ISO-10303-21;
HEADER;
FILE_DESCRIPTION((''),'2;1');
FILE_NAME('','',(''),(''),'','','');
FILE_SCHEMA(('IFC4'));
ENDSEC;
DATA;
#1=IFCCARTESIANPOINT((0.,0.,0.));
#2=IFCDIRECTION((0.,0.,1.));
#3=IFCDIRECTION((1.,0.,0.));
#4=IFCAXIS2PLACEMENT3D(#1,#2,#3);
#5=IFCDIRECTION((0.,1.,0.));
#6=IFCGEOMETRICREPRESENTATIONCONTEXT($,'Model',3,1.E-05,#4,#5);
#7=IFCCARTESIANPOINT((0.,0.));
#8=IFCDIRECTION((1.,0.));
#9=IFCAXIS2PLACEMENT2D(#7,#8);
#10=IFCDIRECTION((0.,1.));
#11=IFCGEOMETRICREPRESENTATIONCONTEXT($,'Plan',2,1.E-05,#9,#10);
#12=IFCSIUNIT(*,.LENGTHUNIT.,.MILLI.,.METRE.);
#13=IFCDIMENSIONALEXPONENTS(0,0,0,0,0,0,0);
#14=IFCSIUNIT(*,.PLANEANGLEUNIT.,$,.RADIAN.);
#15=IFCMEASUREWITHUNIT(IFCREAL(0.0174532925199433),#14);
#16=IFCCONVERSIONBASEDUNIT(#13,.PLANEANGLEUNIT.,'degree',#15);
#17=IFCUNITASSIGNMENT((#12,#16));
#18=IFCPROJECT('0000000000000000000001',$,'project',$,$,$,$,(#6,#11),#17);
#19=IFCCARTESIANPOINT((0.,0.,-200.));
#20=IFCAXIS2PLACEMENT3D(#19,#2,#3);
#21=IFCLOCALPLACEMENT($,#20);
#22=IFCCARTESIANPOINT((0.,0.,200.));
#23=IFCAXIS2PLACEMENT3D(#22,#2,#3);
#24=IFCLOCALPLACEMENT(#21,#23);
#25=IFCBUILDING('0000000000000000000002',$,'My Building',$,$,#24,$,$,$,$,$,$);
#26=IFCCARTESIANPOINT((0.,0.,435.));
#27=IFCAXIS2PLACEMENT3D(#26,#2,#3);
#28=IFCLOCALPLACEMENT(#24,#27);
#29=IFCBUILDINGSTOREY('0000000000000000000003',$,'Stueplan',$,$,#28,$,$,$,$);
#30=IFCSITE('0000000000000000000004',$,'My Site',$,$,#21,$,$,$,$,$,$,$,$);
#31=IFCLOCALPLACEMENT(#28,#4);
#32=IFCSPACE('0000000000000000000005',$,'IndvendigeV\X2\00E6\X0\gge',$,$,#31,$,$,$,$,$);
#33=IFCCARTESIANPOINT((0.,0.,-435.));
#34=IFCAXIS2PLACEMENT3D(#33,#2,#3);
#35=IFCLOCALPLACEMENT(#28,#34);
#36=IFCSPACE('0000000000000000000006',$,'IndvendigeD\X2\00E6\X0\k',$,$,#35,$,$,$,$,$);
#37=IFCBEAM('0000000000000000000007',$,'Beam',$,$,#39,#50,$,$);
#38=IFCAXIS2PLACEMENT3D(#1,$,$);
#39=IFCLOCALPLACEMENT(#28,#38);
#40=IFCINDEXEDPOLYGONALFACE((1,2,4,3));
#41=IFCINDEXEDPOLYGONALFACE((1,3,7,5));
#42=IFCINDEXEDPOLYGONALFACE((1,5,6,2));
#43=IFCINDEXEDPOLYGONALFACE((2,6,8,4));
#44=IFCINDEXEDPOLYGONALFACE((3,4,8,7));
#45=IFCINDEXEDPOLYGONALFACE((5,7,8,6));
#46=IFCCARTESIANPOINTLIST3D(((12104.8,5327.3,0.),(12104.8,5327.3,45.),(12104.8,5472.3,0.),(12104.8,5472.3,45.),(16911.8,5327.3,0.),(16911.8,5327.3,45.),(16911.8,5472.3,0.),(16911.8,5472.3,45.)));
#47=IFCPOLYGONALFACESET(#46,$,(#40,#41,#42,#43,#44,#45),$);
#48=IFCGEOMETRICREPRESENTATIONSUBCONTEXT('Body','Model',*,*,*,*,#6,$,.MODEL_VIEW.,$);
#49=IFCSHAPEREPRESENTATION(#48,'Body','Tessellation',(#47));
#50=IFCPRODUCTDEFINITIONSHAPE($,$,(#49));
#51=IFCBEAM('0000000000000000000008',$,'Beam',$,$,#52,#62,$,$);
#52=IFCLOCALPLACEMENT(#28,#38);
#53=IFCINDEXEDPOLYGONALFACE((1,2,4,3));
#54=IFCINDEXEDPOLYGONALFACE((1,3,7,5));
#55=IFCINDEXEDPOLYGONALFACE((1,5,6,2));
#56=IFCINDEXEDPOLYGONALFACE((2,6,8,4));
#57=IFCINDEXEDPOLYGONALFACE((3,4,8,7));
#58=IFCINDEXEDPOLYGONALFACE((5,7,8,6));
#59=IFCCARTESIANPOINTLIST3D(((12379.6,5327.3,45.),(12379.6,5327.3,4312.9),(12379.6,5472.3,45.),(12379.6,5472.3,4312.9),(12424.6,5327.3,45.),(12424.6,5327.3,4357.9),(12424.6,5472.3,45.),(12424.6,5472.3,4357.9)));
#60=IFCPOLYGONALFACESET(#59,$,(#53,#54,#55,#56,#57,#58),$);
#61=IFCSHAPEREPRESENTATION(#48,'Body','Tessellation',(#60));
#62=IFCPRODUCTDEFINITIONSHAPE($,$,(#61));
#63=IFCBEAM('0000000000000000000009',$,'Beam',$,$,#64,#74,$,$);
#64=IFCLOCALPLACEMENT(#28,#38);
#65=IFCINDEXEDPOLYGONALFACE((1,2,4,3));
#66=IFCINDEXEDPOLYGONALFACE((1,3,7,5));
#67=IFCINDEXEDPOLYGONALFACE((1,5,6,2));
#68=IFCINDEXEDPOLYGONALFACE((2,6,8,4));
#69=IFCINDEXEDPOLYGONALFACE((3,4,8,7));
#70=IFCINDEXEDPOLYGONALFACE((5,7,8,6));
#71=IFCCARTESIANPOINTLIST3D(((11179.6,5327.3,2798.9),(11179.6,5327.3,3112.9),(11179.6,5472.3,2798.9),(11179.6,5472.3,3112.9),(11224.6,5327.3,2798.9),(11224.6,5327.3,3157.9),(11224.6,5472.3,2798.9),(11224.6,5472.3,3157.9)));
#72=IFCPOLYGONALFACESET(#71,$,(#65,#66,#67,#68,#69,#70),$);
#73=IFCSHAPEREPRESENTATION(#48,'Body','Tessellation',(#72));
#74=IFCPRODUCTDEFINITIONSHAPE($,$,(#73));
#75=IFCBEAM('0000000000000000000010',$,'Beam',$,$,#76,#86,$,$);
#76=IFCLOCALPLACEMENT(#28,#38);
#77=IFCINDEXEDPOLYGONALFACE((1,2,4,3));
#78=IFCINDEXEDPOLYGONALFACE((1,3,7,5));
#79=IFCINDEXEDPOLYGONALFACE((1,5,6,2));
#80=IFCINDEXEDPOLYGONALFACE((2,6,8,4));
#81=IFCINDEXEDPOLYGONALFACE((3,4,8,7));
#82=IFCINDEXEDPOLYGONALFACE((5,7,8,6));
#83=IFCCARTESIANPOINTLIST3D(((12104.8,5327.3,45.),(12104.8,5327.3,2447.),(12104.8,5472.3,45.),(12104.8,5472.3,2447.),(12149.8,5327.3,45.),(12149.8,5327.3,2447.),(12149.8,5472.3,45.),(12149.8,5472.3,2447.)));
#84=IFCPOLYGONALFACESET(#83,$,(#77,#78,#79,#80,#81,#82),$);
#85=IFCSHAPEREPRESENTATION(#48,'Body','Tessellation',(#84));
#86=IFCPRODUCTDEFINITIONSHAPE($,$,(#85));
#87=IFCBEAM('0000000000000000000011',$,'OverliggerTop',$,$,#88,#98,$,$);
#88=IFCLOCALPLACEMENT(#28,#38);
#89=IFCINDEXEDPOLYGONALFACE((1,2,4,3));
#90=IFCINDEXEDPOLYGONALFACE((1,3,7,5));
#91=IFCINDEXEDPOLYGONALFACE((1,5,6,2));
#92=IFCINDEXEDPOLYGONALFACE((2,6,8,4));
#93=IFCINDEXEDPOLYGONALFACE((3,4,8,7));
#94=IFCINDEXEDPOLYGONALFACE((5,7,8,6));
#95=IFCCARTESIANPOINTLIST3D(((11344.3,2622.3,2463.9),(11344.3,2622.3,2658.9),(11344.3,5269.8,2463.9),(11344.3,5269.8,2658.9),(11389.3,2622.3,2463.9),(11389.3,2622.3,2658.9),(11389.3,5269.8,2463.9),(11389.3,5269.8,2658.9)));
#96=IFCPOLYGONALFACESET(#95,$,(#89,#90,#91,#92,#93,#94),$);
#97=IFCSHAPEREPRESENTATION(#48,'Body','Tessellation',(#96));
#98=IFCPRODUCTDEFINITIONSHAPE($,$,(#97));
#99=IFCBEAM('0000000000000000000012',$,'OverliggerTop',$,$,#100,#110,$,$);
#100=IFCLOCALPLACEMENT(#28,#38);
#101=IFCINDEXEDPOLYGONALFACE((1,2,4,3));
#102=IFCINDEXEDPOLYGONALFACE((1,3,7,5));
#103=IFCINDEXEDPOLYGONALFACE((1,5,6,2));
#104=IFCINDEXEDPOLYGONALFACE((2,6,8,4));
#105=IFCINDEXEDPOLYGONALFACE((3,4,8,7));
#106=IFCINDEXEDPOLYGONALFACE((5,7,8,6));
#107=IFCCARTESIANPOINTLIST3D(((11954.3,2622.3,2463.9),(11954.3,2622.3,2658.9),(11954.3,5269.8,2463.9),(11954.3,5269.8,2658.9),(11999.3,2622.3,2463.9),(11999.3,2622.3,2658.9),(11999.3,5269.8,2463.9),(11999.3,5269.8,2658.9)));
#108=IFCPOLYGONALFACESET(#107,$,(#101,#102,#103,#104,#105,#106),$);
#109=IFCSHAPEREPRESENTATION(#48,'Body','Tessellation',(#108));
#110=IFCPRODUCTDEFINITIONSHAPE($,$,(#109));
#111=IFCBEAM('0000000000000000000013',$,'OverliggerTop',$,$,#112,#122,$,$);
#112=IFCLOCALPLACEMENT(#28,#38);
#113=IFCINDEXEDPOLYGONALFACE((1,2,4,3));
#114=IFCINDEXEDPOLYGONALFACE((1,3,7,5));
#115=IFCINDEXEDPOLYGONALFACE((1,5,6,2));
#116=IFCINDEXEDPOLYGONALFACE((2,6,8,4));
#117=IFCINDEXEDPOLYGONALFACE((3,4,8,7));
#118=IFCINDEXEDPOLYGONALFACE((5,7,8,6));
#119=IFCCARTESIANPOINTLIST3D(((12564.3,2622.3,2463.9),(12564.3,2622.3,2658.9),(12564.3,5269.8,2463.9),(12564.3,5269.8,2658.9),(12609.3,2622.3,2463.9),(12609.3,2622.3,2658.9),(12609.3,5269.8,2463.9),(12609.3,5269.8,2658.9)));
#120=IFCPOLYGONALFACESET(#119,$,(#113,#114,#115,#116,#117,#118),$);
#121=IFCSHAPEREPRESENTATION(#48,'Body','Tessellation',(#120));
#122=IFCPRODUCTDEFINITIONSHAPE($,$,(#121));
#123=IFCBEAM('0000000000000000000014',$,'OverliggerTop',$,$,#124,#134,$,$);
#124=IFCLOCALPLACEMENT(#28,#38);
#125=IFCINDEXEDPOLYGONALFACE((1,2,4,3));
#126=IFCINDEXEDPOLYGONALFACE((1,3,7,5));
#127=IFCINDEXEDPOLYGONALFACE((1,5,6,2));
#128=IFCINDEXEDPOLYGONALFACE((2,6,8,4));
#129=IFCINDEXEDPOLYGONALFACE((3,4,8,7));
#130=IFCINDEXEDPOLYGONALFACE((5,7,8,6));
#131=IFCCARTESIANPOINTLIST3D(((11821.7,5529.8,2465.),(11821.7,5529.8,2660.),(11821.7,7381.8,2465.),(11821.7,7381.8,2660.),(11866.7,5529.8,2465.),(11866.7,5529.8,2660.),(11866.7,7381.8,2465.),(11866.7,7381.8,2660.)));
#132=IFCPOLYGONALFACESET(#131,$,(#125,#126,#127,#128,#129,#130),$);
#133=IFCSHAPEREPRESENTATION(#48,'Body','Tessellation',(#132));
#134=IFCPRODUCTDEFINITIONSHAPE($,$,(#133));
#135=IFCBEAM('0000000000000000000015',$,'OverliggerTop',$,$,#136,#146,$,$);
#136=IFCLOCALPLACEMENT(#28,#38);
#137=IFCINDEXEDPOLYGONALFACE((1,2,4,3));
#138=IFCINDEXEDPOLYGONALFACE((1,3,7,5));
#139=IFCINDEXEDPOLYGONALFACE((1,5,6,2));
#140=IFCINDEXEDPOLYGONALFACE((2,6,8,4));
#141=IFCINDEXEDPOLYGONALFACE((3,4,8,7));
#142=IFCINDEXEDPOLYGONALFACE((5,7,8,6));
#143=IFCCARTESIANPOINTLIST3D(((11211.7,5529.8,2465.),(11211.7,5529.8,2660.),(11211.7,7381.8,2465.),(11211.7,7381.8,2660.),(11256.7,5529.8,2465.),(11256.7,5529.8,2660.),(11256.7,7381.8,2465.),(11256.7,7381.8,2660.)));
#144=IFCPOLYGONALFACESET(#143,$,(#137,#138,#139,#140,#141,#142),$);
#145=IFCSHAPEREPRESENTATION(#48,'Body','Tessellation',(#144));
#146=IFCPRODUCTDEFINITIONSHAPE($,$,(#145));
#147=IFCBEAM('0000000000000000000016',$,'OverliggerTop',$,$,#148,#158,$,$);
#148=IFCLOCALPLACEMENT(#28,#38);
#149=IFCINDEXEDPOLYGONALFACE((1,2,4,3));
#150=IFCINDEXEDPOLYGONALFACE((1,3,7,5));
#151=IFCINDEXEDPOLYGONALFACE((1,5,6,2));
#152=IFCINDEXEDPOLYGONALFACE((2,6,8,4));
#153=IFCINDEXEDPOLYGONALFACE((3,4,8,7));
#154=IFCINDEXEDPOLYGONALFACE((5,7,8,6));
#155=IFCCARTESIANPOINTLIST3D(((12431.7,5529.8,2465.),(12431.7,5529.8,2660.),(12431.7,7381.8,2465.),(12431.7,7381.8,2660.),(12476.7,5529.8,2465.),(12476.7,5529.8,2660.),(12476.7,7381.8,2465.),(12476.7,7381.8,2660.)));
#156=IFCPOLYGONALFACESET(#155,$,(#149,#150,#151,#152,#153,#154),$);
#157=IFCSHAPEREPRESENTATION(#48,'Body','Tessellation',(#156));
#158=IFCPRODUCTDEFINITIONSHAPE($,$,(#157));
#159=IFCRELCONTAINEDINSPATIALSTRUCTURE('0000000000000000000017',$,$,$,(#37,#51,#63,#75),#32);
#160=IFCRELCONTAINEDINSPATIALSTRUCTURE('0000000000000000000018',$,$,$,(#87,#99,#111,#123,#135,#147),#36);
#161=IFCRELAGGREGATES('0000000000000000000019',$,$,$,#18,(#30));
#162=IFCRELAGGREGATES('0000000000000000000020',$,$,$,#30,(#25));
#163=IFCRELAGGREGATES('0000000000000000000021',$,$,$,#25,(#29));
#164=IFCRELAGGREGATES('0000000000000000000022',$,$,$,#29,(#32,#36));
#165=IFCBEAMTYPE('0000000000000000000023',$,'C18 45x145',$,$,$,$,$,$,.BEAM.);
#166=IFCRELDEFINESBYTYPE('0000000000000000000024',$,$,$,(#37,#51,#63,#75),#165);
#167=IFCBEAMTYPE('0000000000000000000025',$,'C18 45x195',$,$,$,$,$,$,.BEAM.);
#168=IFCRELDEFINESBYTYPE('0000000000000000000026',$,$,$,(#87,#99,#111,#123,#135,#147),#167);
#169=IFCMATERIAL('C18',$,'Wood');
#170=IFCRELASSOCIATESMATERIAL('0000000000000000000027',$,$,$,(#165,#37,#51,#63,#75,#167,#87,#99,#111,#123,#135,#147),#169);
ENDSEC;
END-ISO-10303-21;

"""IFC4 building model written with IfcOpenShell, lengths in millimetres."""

from ifc_helpers import new_model, entity, si_unit, converted_unit, direction, frame, origin_with_axes, origin_2d_with_axis, place, context, subcontext, project, spatial, rectangle, extrude, clip, halfspace, material, material_profile, profile_set, profile_usage, type_object, element, save


model = new_model("IFC4")

# Units and contexts
model_context = context("Model", 3, precision=1e-05, world=origin_with_axes(), true_north=direction((0.0, 1.0, 0.0)))
plan_context = context("Plan", 2, precision=1e-05, world=origin_2d_with_axis(), true_north=direction((0.0, 1.0)))
body_context_1 = subcontext(model_context, "Body", "Model", "MODEL_VIEW")
ifc_project = project(units=[si_unit("LENGTHUNIT", "METRE", prefix="MILLI"), converted_unit("PLANEANGLEUNIT", "degree", entity("IfcReal", 0.0174532925199433), si_unit("PLANEANGLEUNIT", "RADIAN"), dimensions=[0, 0, 0, 0, 0, 0, 0])], contexts=[model_context, plan_context])

# Site, building, storey, space
site_placement = place(None, frame((0.0, 0.0, -200.0), z_axis=(0.0, 0.0, 1.0), x_axis=(1.0, 0.0, 0.0)))
site = spatial("IfcSite", under=ifc_project, at=site_placement, Name="My Site")
building_placement = place(site_placement, frame((0.0, 0.0, 200.0), z_axis=(0.0, 0.0, 1.0), x_axis=(1.0, 0.0, 0.0)))
building = spatial("IfcBuilding", under=site, at=building_placement, Name="My Building")
storey_placement = place(building_placement, frame((0.0, 0.0, 435.0), z_axis=(0.0, 0.0, 1.0), x_axis=(1.0, 0.0, 0.0)))
storey = spatial("IfcBuildingStorey", under=building, at=storey_placement, Name="Stueplan")
space_1_placement = place(storey_placement, frame((0.0, 0.0, 0.0), z_axis=(0.0, 0.0, 1.0), x_axis=(1.0, 0.0, 0.0)))
space_1 = spatial("IfcSpace", under=storey, at=space_1_placement, Name="IndvendigeVægge")

# Beams
ifc_material = material(Name="C18", Category="Wood")
ifc_material_profile_1 = material_profile(ifc_material, rectangle(XDim=45.0, YDim=145.0))
ifc_profile_set_1 = profile_set([ifc_material_profile_1], Name="woodStructural")
beam_type_1 = type_object("IfcBeamType", Name="C18 45x145", PredefinedType="BEAM", material=ifc_profile_set_1)
ifc_profile_usage_1 = profile_usage(ifc_profile_set_1)
beam_1_placement = place(space_1_placement, frame((12104.8, 5399.8, 22.5), z_axis=(1.0, 0.0, 0.0), x_axis=(0.0, 0.0, 1.0)))
element("IfcBeam", 1, at=beam_1_placement, inside=space_1, type_object=beam_type_1, material=ifc_profile_usage_1, Name="Beam", context=body_context_1, shape_type="SweptSolid", body=[
    extrude(rectangle(XDim=45.0, YDim=145.0), origin_with_axes(), (0.0, 0.0, 1.0), 4807.0),
])
ifc_profile_usage_2 = profile_usage(ifc_profile_set_1)
beam_2_placement = place(space_1_placement, frame((12402.1, 5399.8, 45.0), z_axis=(0.0, 0.0, 1.0), x_axis=(-1.0, 0.0, 0.0)))
element("IfcBeam", 2, at=beam_2_placement, inside=space_1, type_object=beam_type_1, material=ifc_profile_usage_2, Name="Beam", context=body_context_1, shape_type="Clipping", body=[
    clip(extrude(rectangle(XDim=45.0, YDim=145.0), origin_with_axes(), (0.0, 0.0, 1.0), 4435.4), halfspace(frame((-1439.0, 0.0, 5729.4), z_axis=(0.707107, 0.0, 0.707107), x_axis=(0.0, -1.0, 0.0)), False)),
])
ifc_profile_usage_3 = profile_usage(ifc_profile_set_1)
beam_3_placement = place(space_1_placement, frame((11202.1, 5399.8, 2798.9), z_axis=(0.0, 0.0, 1.0), x_axis=(-1.0, 0.0, 0.0)))
element("IfcBeam", 3, at=beam_3_placement, inside=space_1, type_object=beam_type_1, material=ifc_profile_usage_3, Name="Beam", context=body_context_1, shape_type="Clipping", body=[
    clip(extrude(rectangle(XDim=45.0, YDim=145.0), origin_with_axes(), (0.0, 0.0, 1.0), 481.4), halfspace(frame((-2712.8, 0.0, 3049.3), z_axis=(0.707107, 0.0, 0.707107), x_axis=(0.0, -1.0, 0.0)), False)),
])
ifc_profile_usage_4 = profile_usage(ifc_profile_set_1)
beam_4_placement = place(space_1_placement, frame((12127.3, 5399.8, 45.0), z_axis=(0.0, 0.0, 1.0), x_axis=(-1.0, 0.0, 0.0)))
element("IfcBeam", 4, at=beam_4_placement, inside=space_1, type_object=beam_type_1, material=ifc_profile_usage_4, Name="Beam", context=body_context_1, shape_type="SweptSolid", body=[
    extrude(rectangle(XDim=45.0, YDim=145.0), origin_with_axes(), (0.0, 0.0, 1.0), 2402.0),
])

# Shared definitions
space_2_placement = place(storey_placement, frame((0.0, 0.0, -435.0), z_axis=(0.0, 0.0, 1.0), x_axis=(1.0, 0.0, 0.0)))
space_2 = spatial("IfcSpace", under=storey, at=space_2_placement, Name="IndvendigeDæk")

# Beams
ifc_material_profile_2 = material_profile(ifc_material, rectangle(XDim=45.0, YDim=195.0))
ifc_profile_set_2 = profile_set([ifc_material_profile_2], Name="woodStructural")
ifc_profile_usage_5 = profile_usage(ifc_profile_set_2)
beam_type_2 = type_object("IfcBeamType", Name="C18 45x195", PredefinedType="BEAM", material=ifc_profile_set_2)
beam_5_placement = place(space_2_placement, frame((11366.8, 5269.8, 2996.4), z_axis=(0.000001, -1.0, 0.0), x_axis=(-1.0, -0.000001, 0.0)))
element("IfcBeam", 5, at=beam_5_placement, inside=space_2, type_object=beam_type_2, material=ifc_profile_usage_5, Name="OverliggerTop", context=body_context_1, shape_type="SweptSolid", body=[
    extrude(rectangle(XDim=45.0, YDim=195.0), origin_with_axes(), (0.0, 0.0, 1.0), 2647.5),
])
ifc_profile_usage_6 = profile_usage(ifc_profile_set_2)
beam_6_placement = place(space_2_placement, frame((11976.8, 5269.8, 2996.4), z_axis=(0.000001, -1.0, 0.0), x_axis=(-1.0, -0.000001, 0.0)))
element("IfcBeam", 6, at=beam_6_placement, inside=space_2, type_object=beam_type_2, material=ifc_profile_usage_6, Name="OverliggerTop", context=body_context_1, shape_type="SweptSolid", body=[
    extrude(rectangle(XDim=45.0, YDim=195.0), origin_with_axes(), (0.0, 0.0, 1.0), 2647.5),
])
ifc_profile_usage_7 = profile_usage(ifc_profile_set_2)
beam_7_placement = place(space_2_placement, frame((12586.8, 5269.8, 2996.4), z_axis=(0.000001, -1.0, 0.0), x_axis=(-1.0, -0.000001, 0.0)))
element("IfcBeam", 7, at=beam_7_placement, inside=space_2, type_object=beam_type_2, material=ifc_profile_usage_7, Name="OverliggerTop", context=body_context_1, shape_type="SweptSolid", body=[
    extrude(rectangle(XDim=45.0, YDim=195.0), origin_with_axes(), (0.0, 0.0, 1.0), 2647.5),
])
ifc_profile_usage_8 = profile_usage(ifc_profile_set_2)
beam_8_placement = place(space_2_placement, frame((11844.2, 7381.8, 2997.5), z_axis=(0.000001, -1.0, 0.0), x_axis=(-1.0, -0.000001, 0.0)))
element("IfcBeam", 8, at=beam_8_placement, inside=space_2, type_object=beam_type_2, material=ifc_profile_usage_8, Name="OverliggerTop", context=body_context_1, shape_type="SweptSolid", body=[
    extrude(rectangle(XDim=45.0, YDim=195.0), origin_with_axes(), (0.0, 0.0, 1.0), 1852.0),
])
ifc_profile_usage_9 = profile_usage(ifc_profile_set_2)
beam_9_placement = place(space_2_placement, frame((11234.2, 7381.8, 2997.5), z_axis=(0.000001, -1.0, 0.0), x_axis=(-1.0, -0.000001, 0.0)))
element("IfcBeam", 9, at=beam_9_placement, inside=space_2, type_object=beam_type_2, material=ifc_profile_usage_9, Name="OverliggerTop", context=body_context_1, shape_type="SweptSolid", body=[
    extrude(rectangle(XDim=45.0, YDim=195.0), origin_with_axes(), (0.0, 0.0, 1.0), 1852.0),
])
ifc_profile_usage_10 = profile_usage(ifc_profile_set_2)
beam_10_placement = place(space_2_placement, frame((12454.2, 7381.8, 2997.5), z_axis=(0.000001, -1.0, 0.0), x_axis=(-1.0, -0.000001, 0.0)))
element("IfcBeam", 10, at=beam_10_placement, inside=space_2, type_object=beam_type_2, material=ifc_profile_usage_10, Name="OverliggerTop", context=body_context_1, shape_type="SweptSolid", body=[
    extrude(rectangle(XDim=45.0, YDim=195.0), origin_with_axes(), (0.0, 0.0, 1.0), 1852.0),
])

save(model, "model.ifc")
